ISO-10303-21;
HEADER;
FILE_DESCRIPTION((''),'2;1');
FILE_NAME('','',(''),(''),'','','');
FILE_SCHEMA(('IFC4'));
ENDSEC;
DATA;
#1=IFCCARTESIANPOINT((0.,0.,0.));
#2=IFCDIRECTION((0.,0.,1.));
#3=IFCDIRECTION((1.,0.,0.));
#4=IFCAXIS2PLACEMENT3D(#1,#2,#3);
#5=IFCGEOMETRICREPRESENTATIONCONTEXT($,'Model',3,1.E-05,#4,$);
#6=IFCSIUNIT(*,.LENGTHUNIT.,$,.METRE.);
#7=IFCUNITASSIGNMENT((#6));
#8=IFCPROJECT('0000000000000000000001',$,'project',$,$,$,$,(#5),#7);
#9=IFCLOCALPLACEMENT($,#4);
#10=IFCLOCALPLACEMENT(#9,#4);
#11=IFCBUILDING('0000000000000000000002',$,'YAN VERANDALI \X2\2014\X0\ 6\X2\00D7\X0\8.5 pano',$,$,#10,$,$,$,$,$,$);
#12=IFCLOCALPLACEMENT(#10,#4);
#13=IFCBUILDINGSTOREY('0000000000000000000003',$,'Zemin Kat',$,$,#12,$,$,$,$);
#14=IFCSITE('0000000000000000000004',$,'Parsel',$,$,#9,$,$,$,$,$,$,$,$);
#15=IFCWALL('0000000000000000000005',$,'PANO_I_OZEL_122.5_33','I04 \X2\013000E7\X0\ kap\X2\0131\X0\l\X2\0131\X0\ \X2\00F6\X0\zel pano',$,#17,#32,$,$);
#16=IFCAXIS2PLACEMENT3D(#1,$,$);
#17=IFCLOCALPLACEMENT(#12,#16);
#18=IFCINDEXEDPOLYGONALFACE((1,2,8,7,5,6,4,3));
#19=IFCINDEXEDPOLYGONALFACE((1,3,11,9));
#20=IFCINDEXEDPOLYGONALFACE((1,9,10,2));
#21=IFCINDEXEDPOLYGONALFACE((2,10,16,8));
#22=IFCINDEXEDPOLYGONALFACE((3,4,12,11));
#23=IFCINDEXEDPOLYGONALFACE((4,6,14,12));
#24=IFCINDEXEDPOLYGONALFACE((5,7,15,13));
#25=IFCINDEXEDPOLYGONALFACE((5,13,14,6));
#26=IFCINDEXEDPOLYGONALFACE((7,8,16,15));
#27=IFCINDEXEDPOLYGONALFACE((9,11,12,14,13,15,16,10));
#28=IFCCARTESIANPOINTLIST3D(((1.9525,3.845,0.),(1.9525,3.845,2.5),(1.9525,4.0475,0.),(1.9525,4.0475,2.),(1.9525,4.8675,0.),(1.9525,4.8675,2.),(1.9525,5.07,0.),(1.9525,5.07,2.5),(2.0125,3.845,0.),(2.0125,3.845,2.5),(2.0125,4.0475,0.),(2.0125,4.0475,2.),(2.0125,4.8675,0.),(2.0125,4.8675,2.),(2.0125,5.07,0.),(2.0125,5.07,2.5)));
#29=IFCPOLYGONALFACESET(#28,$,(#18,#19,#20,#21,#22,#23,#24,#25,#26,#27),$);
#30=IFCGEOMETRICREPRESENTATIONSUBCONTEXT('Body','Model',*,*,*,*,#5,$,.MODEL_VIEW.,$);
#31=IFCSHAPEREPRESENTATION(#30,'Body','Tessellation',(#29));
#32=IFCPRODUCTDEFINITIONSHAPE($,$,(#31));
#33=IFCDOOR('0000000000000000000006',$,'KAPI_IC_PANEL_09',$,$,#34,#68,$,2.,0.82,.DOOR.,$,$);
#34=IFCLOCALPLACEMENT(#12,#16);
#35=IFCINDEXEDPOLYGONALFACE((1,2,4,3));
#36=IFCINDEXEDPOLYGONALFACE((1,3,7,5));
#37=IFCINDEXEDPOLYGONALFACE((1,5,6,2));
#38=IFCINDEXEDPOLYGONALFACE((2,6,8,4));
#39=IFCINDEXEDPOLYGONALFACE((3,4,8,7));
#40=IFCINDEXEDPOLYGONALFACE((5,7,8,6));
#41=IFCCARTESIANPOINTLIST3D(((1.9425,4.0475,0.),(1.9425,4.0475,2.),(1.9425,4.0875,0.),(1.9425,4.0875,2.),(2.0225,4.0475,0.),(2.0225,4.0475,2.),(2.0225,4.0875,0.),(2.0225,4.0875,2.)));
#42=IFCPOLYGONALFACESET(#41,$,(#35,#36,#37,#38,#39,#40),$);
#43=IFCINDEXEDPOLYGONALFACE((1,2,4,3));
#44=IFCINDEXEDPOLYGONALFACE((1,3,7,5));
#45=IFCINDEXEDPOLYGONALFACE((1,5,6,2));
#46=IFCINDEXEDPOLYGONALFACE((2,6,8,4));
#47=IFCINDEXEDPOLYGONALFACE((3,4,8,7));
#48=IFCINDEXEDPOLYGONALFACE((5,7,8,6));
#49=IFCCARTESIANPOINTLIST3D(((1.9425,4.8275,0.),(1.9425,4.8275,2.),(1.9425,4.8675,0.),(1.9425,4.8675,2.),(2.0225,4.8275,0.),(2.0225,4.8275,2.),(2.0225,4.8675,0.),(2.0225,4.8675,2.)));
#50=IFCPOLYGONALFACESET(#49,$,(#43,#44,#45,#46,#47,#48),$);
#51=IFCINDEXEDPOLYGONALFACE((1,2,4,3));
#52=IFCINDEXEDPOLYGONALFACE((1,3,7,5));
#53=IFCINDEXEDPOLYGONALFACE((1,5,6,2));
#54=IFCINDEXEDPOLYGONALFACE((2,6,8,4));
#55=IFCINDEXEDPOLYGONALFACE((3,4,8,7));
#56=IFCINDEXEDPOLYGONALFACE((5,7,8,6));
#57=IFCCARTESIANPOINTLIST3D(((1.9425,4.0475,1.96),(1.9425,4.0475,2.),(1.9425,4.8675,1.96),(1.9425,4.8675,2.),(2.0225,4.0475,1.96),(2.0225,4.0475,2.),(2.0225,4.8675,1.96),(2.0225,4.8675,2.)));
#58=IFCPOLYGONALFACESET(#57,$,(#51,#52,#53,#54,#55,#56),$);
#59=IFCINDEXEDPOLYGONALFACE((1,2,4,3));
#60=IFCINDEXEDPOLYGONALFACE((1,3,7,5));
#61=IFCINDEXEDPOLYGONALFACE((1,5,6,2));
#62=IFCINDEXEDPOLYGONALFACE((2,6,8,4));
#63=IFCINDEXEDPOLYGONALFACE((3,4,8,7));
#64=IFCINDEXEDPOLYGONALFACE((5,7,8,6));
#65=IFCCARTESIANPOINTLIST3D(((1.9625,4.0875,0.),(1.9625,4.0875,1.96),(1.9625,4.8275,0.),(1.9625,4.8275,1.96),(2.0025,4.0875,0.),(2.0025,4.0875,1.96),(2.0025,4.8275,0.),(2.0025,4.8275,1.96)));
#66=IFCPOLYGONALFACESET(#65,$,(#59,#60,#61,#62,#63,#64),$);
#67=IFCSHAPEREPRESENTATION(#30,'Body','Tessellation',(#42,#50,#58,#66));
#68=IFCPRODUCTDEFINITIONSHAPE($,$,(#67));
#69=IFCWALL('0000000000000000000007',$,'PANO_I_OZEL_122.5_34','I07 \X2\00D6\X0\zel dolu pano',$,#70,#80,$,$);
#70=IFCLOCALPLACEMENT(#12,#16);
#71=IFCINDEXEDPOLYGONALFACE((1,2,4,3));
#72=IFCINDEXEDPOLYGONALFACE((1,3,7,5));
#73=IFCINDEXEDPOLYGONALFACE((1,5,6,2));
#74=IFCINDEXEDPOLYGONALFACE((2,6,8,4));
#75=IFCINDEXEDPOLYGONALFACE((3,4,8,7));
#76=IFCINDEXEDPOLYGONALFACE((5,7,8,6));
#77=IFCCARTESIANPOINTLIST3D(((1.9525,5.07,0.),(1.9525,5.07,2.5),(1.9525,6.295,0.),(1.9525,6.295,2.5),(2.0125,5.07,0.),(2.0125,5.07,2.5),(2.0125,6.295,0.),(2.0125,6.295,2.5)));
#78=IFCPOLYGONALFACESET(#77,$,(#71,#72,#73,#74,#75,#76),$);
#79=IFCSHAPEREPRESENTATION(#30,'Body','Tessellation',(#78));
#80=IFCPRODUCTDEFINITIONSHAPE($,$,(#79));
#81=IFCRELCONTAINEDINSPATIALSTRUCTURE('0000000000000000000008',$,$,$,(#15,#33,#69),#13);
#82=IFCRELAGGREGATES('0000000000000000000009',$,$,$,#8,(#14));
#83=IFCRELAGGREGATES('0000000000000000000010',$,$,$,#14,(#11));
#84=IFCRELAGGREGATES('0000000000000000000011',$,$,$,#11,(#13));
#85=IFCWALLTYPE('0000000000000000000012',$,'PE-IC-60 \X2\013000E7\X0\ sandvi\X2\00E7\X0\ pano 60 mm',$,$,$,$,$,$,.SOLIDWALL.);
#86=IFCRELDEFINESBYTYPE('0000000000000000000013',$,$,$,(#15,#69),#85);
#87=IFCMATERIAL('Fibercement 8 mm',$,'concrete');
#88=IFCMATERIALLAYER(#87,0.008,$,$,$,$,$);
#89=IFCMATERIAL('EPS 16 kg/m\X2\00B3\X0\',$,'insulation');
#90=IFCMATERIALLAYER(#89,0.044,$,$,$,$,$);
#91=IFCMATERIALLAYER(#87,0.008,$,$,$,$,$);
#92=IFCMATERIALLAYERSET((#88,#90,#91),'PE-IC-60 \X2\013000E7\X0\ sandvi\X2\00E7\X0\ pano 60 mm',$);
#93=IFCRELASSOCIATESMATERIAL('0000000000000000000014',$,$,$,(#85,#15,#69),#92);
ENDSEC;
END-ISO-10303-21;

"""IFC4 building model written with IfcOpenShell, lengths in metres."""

from ifc_helpers import new_model, si_unit, frame, origin_with_axes, place, context, subcontext, project, spatial, line, indexed_curve, outline, extrude, material, layer, layer_set, layer_usage, type_object, element, fill, save


model = new_model("IFC4")

# Units and contexts
model_context = context("Model", 3, precision=1e-05, world=origin_with_axes())
body_context = subcontext(model_context, "Body", "Model", "MODEL_VIEW")
ifc_project = project(units=[si_unit("LENGTHUNIT", "METRE")], contexts=[model_context])

# Site, building, storey
site_placement = place(None, origin_with_axes())
site = spatial("IfcSite", under=ifc_project, at=site_placement, Name="Parsel")
building_placement = place(site_placement, origin_with_axes())
building = spatial("IfcBuilding", under=site, at=building_placement, Name="YAN VERANDALI — 6×8.5 pano")
storey_placement = place(building_placement, origin_with_axes())
storey = spatial("IfcBuildingStorey", under=building, at=storey_placement, Name="Zemin Kat")

# Shared definitions
ifc_material_1 = material(Name="Fibercement 8 mm", Category="concrete")
ifc_material_2 = material(Name="EPS 16 kg/m³", Category="insulation")

# Shared definitions
ifc_layer_1 = layer(ifc_material_1, 0.008)
ifc_layer_2 = layer(ifc_material_2, 0.044)
ifc_layer_3 = layer(ifc_material_1, 0.008)
ifc_layer_set_1 = layer_set([ifc_layer_1, ifc_layer_2, ifc_layer_3], Name="PE-IC-60 İç sandviç pano 60 mm")
wall_type_1 = type_object("IfcWallType", Name="PE-IC-60 İç sandviç pano 60 mm", PredefinedType="SOLIDWALL", material=ifc_layer_set_1)

# Wall, opening, door
ifc_layer_usage_1 = layer_usage(ifc_layer_set_1, "AXIS2", "POSITIVE", 0.0)
wall_1_placement = place(storey_placement, frame((2.0125, 3.845, 0.0), z_axis=(0.0, 0.0, 1.0), x_axis=(0.0, 1.0, 0.0)))
wall_1 = element("IfcWall", 1, at=wall_1_placement, inside=storey, type_object=wall_type_1, material=ifc_layer_usage_1, Name="PANO_I_OZEL_122.5_33", Description="I04 İç kapılı özel pano", context=body_context, shape_type="SweptSolid", body=[
    extrude(outline(indexed_curve([(0.0, 0.0), (1.225, 0.0), (1.225, 0.06), (0.0, 0.06)], segments=[line(1, 2, 3, 4, 1)])), origin_with_axes(), (0.0, 0.0, 1.0), 2.5),
])
opening_1_placement = place(wall_1_placement, origin_with_axes())
opening_1 = element("IfcOpeningElement", 2, at=opening_1_placement, cuts=wall_1, PredefinedType="OPENING", context=body_context, shape_type="SweptSolid", body=[
    extrude(outline(indexed_curve([(0.0, 0.0), (0.82, 0.0), (0.82, 0.1), (0.0, 0.1)], segments=[line(1, 2, 3, 4, 1)])), frame((0.2025, -0.02, 0.0), z_axis=(0.0, 0.0, 1.0), x_axis=(1.0, 0.0, 0.0)), (0.0, 0.0, 1.0), 2.0),
])
door_1_placement = place(storey_placement, frame((2.0125, 3.845, 0.0), z_axis=(0.0, 0.0, 1.0), x_axis=(0.0, 1.0, 0.0)))
door_1 = element("IfcDoor", 3, at=door_1_placement, inside=storey, Name="KAPI_IC_PANEL_09", OverallHeight=2.0, OverallWidth=0.82, PredefinedType="DOOR", context=body_context, shape_type="SweptSolid", body=[
    extrude(outline(indexed_curve([(0.0, 0.0), (0.04, 0.0), (0.04, 0.08), (0.0, 0.08)], segments=[line(1, 2, 3, 4, 1)])), frame((0.2025, -0.01, 0.0), z_axis=(0.0, 0.0, 1.0), x_axis=(1.0, 0.0, 0.0)), (0.0, 0.0, 1.0), 2.0),
    extrude(outline(indexed_curve([(0.0, 0.0), (0.04, 0.0), (0.04, 0.08), (0.0, 0.08)], segments=[line(1, 2, 3, 4, 1)])), frame((0.9825, -0.01, 0.0), z_axis=(0.0, 0.0, 1.0), x_axis=(1.0, 0.0, 0.0)), (0.0, 0.0, 1.0), 2.0),
    extrude(outline(indexed_curve([(0.0, 0.0), (0.82, 0.0), (0.82, 0.08), (0.0, 0.08)], segments=[line(1, 2, 3, 4, 1)])), frame((0.2025, -0.01, 1.96), z_axis=(0.0, 0.0, 1.0), x_axis=(1.0, 0.0, 0.0)), (0.0, 0.0, 1.0), 0.04),
    extrude(outline(indexed_curve([(0.0, 0.0), (0.74, 0.0), (0.74, 0.04), (0.0, 0.04)], segments=[line(1, 2, 3, 4, 1)])), frame((0.2425, 0.01, 0.0), z_axis=(0.0, 0.0, 1.0), x_axis=(1.0, 0.0, 0.0)), (0.0, 0.0, 1.0), 1.96),
])
fill(opening_1, door_1)

# Wall
ifc_layer_usage_2 = layer_usage(ifc_layer_set_1, "AXIS2", "POSITIVE", 0.0)
wall_2_placement = place(storey_placement, frame((2.0125, 5.07, 0.0), z_axis=(0.0, 0.0, 1.0), x_axis=(0.0, 1.0, 0.0)))
element("IfcWall", 4, at=wall_2_placement, inside=storey, type_object=wall_type_1, material=ifc_layer_usage_2, Name="PANO_I_OZEL_122.5_34", Description="I07 Özel dolu pano", context=body_context, shape_type="SweptSolid", body=[
    extrude(outline(indexed_curve([(0.0, 0.0), (1.225, 0.0), (1.225, 0.06), (0.0, 0.06)], segments=[line(1, 2, 3, 4, 1)])), origin_with_axes(), (0.0, 0.0, 1.0), 2.5),
])

save(model, "model.ifc")
